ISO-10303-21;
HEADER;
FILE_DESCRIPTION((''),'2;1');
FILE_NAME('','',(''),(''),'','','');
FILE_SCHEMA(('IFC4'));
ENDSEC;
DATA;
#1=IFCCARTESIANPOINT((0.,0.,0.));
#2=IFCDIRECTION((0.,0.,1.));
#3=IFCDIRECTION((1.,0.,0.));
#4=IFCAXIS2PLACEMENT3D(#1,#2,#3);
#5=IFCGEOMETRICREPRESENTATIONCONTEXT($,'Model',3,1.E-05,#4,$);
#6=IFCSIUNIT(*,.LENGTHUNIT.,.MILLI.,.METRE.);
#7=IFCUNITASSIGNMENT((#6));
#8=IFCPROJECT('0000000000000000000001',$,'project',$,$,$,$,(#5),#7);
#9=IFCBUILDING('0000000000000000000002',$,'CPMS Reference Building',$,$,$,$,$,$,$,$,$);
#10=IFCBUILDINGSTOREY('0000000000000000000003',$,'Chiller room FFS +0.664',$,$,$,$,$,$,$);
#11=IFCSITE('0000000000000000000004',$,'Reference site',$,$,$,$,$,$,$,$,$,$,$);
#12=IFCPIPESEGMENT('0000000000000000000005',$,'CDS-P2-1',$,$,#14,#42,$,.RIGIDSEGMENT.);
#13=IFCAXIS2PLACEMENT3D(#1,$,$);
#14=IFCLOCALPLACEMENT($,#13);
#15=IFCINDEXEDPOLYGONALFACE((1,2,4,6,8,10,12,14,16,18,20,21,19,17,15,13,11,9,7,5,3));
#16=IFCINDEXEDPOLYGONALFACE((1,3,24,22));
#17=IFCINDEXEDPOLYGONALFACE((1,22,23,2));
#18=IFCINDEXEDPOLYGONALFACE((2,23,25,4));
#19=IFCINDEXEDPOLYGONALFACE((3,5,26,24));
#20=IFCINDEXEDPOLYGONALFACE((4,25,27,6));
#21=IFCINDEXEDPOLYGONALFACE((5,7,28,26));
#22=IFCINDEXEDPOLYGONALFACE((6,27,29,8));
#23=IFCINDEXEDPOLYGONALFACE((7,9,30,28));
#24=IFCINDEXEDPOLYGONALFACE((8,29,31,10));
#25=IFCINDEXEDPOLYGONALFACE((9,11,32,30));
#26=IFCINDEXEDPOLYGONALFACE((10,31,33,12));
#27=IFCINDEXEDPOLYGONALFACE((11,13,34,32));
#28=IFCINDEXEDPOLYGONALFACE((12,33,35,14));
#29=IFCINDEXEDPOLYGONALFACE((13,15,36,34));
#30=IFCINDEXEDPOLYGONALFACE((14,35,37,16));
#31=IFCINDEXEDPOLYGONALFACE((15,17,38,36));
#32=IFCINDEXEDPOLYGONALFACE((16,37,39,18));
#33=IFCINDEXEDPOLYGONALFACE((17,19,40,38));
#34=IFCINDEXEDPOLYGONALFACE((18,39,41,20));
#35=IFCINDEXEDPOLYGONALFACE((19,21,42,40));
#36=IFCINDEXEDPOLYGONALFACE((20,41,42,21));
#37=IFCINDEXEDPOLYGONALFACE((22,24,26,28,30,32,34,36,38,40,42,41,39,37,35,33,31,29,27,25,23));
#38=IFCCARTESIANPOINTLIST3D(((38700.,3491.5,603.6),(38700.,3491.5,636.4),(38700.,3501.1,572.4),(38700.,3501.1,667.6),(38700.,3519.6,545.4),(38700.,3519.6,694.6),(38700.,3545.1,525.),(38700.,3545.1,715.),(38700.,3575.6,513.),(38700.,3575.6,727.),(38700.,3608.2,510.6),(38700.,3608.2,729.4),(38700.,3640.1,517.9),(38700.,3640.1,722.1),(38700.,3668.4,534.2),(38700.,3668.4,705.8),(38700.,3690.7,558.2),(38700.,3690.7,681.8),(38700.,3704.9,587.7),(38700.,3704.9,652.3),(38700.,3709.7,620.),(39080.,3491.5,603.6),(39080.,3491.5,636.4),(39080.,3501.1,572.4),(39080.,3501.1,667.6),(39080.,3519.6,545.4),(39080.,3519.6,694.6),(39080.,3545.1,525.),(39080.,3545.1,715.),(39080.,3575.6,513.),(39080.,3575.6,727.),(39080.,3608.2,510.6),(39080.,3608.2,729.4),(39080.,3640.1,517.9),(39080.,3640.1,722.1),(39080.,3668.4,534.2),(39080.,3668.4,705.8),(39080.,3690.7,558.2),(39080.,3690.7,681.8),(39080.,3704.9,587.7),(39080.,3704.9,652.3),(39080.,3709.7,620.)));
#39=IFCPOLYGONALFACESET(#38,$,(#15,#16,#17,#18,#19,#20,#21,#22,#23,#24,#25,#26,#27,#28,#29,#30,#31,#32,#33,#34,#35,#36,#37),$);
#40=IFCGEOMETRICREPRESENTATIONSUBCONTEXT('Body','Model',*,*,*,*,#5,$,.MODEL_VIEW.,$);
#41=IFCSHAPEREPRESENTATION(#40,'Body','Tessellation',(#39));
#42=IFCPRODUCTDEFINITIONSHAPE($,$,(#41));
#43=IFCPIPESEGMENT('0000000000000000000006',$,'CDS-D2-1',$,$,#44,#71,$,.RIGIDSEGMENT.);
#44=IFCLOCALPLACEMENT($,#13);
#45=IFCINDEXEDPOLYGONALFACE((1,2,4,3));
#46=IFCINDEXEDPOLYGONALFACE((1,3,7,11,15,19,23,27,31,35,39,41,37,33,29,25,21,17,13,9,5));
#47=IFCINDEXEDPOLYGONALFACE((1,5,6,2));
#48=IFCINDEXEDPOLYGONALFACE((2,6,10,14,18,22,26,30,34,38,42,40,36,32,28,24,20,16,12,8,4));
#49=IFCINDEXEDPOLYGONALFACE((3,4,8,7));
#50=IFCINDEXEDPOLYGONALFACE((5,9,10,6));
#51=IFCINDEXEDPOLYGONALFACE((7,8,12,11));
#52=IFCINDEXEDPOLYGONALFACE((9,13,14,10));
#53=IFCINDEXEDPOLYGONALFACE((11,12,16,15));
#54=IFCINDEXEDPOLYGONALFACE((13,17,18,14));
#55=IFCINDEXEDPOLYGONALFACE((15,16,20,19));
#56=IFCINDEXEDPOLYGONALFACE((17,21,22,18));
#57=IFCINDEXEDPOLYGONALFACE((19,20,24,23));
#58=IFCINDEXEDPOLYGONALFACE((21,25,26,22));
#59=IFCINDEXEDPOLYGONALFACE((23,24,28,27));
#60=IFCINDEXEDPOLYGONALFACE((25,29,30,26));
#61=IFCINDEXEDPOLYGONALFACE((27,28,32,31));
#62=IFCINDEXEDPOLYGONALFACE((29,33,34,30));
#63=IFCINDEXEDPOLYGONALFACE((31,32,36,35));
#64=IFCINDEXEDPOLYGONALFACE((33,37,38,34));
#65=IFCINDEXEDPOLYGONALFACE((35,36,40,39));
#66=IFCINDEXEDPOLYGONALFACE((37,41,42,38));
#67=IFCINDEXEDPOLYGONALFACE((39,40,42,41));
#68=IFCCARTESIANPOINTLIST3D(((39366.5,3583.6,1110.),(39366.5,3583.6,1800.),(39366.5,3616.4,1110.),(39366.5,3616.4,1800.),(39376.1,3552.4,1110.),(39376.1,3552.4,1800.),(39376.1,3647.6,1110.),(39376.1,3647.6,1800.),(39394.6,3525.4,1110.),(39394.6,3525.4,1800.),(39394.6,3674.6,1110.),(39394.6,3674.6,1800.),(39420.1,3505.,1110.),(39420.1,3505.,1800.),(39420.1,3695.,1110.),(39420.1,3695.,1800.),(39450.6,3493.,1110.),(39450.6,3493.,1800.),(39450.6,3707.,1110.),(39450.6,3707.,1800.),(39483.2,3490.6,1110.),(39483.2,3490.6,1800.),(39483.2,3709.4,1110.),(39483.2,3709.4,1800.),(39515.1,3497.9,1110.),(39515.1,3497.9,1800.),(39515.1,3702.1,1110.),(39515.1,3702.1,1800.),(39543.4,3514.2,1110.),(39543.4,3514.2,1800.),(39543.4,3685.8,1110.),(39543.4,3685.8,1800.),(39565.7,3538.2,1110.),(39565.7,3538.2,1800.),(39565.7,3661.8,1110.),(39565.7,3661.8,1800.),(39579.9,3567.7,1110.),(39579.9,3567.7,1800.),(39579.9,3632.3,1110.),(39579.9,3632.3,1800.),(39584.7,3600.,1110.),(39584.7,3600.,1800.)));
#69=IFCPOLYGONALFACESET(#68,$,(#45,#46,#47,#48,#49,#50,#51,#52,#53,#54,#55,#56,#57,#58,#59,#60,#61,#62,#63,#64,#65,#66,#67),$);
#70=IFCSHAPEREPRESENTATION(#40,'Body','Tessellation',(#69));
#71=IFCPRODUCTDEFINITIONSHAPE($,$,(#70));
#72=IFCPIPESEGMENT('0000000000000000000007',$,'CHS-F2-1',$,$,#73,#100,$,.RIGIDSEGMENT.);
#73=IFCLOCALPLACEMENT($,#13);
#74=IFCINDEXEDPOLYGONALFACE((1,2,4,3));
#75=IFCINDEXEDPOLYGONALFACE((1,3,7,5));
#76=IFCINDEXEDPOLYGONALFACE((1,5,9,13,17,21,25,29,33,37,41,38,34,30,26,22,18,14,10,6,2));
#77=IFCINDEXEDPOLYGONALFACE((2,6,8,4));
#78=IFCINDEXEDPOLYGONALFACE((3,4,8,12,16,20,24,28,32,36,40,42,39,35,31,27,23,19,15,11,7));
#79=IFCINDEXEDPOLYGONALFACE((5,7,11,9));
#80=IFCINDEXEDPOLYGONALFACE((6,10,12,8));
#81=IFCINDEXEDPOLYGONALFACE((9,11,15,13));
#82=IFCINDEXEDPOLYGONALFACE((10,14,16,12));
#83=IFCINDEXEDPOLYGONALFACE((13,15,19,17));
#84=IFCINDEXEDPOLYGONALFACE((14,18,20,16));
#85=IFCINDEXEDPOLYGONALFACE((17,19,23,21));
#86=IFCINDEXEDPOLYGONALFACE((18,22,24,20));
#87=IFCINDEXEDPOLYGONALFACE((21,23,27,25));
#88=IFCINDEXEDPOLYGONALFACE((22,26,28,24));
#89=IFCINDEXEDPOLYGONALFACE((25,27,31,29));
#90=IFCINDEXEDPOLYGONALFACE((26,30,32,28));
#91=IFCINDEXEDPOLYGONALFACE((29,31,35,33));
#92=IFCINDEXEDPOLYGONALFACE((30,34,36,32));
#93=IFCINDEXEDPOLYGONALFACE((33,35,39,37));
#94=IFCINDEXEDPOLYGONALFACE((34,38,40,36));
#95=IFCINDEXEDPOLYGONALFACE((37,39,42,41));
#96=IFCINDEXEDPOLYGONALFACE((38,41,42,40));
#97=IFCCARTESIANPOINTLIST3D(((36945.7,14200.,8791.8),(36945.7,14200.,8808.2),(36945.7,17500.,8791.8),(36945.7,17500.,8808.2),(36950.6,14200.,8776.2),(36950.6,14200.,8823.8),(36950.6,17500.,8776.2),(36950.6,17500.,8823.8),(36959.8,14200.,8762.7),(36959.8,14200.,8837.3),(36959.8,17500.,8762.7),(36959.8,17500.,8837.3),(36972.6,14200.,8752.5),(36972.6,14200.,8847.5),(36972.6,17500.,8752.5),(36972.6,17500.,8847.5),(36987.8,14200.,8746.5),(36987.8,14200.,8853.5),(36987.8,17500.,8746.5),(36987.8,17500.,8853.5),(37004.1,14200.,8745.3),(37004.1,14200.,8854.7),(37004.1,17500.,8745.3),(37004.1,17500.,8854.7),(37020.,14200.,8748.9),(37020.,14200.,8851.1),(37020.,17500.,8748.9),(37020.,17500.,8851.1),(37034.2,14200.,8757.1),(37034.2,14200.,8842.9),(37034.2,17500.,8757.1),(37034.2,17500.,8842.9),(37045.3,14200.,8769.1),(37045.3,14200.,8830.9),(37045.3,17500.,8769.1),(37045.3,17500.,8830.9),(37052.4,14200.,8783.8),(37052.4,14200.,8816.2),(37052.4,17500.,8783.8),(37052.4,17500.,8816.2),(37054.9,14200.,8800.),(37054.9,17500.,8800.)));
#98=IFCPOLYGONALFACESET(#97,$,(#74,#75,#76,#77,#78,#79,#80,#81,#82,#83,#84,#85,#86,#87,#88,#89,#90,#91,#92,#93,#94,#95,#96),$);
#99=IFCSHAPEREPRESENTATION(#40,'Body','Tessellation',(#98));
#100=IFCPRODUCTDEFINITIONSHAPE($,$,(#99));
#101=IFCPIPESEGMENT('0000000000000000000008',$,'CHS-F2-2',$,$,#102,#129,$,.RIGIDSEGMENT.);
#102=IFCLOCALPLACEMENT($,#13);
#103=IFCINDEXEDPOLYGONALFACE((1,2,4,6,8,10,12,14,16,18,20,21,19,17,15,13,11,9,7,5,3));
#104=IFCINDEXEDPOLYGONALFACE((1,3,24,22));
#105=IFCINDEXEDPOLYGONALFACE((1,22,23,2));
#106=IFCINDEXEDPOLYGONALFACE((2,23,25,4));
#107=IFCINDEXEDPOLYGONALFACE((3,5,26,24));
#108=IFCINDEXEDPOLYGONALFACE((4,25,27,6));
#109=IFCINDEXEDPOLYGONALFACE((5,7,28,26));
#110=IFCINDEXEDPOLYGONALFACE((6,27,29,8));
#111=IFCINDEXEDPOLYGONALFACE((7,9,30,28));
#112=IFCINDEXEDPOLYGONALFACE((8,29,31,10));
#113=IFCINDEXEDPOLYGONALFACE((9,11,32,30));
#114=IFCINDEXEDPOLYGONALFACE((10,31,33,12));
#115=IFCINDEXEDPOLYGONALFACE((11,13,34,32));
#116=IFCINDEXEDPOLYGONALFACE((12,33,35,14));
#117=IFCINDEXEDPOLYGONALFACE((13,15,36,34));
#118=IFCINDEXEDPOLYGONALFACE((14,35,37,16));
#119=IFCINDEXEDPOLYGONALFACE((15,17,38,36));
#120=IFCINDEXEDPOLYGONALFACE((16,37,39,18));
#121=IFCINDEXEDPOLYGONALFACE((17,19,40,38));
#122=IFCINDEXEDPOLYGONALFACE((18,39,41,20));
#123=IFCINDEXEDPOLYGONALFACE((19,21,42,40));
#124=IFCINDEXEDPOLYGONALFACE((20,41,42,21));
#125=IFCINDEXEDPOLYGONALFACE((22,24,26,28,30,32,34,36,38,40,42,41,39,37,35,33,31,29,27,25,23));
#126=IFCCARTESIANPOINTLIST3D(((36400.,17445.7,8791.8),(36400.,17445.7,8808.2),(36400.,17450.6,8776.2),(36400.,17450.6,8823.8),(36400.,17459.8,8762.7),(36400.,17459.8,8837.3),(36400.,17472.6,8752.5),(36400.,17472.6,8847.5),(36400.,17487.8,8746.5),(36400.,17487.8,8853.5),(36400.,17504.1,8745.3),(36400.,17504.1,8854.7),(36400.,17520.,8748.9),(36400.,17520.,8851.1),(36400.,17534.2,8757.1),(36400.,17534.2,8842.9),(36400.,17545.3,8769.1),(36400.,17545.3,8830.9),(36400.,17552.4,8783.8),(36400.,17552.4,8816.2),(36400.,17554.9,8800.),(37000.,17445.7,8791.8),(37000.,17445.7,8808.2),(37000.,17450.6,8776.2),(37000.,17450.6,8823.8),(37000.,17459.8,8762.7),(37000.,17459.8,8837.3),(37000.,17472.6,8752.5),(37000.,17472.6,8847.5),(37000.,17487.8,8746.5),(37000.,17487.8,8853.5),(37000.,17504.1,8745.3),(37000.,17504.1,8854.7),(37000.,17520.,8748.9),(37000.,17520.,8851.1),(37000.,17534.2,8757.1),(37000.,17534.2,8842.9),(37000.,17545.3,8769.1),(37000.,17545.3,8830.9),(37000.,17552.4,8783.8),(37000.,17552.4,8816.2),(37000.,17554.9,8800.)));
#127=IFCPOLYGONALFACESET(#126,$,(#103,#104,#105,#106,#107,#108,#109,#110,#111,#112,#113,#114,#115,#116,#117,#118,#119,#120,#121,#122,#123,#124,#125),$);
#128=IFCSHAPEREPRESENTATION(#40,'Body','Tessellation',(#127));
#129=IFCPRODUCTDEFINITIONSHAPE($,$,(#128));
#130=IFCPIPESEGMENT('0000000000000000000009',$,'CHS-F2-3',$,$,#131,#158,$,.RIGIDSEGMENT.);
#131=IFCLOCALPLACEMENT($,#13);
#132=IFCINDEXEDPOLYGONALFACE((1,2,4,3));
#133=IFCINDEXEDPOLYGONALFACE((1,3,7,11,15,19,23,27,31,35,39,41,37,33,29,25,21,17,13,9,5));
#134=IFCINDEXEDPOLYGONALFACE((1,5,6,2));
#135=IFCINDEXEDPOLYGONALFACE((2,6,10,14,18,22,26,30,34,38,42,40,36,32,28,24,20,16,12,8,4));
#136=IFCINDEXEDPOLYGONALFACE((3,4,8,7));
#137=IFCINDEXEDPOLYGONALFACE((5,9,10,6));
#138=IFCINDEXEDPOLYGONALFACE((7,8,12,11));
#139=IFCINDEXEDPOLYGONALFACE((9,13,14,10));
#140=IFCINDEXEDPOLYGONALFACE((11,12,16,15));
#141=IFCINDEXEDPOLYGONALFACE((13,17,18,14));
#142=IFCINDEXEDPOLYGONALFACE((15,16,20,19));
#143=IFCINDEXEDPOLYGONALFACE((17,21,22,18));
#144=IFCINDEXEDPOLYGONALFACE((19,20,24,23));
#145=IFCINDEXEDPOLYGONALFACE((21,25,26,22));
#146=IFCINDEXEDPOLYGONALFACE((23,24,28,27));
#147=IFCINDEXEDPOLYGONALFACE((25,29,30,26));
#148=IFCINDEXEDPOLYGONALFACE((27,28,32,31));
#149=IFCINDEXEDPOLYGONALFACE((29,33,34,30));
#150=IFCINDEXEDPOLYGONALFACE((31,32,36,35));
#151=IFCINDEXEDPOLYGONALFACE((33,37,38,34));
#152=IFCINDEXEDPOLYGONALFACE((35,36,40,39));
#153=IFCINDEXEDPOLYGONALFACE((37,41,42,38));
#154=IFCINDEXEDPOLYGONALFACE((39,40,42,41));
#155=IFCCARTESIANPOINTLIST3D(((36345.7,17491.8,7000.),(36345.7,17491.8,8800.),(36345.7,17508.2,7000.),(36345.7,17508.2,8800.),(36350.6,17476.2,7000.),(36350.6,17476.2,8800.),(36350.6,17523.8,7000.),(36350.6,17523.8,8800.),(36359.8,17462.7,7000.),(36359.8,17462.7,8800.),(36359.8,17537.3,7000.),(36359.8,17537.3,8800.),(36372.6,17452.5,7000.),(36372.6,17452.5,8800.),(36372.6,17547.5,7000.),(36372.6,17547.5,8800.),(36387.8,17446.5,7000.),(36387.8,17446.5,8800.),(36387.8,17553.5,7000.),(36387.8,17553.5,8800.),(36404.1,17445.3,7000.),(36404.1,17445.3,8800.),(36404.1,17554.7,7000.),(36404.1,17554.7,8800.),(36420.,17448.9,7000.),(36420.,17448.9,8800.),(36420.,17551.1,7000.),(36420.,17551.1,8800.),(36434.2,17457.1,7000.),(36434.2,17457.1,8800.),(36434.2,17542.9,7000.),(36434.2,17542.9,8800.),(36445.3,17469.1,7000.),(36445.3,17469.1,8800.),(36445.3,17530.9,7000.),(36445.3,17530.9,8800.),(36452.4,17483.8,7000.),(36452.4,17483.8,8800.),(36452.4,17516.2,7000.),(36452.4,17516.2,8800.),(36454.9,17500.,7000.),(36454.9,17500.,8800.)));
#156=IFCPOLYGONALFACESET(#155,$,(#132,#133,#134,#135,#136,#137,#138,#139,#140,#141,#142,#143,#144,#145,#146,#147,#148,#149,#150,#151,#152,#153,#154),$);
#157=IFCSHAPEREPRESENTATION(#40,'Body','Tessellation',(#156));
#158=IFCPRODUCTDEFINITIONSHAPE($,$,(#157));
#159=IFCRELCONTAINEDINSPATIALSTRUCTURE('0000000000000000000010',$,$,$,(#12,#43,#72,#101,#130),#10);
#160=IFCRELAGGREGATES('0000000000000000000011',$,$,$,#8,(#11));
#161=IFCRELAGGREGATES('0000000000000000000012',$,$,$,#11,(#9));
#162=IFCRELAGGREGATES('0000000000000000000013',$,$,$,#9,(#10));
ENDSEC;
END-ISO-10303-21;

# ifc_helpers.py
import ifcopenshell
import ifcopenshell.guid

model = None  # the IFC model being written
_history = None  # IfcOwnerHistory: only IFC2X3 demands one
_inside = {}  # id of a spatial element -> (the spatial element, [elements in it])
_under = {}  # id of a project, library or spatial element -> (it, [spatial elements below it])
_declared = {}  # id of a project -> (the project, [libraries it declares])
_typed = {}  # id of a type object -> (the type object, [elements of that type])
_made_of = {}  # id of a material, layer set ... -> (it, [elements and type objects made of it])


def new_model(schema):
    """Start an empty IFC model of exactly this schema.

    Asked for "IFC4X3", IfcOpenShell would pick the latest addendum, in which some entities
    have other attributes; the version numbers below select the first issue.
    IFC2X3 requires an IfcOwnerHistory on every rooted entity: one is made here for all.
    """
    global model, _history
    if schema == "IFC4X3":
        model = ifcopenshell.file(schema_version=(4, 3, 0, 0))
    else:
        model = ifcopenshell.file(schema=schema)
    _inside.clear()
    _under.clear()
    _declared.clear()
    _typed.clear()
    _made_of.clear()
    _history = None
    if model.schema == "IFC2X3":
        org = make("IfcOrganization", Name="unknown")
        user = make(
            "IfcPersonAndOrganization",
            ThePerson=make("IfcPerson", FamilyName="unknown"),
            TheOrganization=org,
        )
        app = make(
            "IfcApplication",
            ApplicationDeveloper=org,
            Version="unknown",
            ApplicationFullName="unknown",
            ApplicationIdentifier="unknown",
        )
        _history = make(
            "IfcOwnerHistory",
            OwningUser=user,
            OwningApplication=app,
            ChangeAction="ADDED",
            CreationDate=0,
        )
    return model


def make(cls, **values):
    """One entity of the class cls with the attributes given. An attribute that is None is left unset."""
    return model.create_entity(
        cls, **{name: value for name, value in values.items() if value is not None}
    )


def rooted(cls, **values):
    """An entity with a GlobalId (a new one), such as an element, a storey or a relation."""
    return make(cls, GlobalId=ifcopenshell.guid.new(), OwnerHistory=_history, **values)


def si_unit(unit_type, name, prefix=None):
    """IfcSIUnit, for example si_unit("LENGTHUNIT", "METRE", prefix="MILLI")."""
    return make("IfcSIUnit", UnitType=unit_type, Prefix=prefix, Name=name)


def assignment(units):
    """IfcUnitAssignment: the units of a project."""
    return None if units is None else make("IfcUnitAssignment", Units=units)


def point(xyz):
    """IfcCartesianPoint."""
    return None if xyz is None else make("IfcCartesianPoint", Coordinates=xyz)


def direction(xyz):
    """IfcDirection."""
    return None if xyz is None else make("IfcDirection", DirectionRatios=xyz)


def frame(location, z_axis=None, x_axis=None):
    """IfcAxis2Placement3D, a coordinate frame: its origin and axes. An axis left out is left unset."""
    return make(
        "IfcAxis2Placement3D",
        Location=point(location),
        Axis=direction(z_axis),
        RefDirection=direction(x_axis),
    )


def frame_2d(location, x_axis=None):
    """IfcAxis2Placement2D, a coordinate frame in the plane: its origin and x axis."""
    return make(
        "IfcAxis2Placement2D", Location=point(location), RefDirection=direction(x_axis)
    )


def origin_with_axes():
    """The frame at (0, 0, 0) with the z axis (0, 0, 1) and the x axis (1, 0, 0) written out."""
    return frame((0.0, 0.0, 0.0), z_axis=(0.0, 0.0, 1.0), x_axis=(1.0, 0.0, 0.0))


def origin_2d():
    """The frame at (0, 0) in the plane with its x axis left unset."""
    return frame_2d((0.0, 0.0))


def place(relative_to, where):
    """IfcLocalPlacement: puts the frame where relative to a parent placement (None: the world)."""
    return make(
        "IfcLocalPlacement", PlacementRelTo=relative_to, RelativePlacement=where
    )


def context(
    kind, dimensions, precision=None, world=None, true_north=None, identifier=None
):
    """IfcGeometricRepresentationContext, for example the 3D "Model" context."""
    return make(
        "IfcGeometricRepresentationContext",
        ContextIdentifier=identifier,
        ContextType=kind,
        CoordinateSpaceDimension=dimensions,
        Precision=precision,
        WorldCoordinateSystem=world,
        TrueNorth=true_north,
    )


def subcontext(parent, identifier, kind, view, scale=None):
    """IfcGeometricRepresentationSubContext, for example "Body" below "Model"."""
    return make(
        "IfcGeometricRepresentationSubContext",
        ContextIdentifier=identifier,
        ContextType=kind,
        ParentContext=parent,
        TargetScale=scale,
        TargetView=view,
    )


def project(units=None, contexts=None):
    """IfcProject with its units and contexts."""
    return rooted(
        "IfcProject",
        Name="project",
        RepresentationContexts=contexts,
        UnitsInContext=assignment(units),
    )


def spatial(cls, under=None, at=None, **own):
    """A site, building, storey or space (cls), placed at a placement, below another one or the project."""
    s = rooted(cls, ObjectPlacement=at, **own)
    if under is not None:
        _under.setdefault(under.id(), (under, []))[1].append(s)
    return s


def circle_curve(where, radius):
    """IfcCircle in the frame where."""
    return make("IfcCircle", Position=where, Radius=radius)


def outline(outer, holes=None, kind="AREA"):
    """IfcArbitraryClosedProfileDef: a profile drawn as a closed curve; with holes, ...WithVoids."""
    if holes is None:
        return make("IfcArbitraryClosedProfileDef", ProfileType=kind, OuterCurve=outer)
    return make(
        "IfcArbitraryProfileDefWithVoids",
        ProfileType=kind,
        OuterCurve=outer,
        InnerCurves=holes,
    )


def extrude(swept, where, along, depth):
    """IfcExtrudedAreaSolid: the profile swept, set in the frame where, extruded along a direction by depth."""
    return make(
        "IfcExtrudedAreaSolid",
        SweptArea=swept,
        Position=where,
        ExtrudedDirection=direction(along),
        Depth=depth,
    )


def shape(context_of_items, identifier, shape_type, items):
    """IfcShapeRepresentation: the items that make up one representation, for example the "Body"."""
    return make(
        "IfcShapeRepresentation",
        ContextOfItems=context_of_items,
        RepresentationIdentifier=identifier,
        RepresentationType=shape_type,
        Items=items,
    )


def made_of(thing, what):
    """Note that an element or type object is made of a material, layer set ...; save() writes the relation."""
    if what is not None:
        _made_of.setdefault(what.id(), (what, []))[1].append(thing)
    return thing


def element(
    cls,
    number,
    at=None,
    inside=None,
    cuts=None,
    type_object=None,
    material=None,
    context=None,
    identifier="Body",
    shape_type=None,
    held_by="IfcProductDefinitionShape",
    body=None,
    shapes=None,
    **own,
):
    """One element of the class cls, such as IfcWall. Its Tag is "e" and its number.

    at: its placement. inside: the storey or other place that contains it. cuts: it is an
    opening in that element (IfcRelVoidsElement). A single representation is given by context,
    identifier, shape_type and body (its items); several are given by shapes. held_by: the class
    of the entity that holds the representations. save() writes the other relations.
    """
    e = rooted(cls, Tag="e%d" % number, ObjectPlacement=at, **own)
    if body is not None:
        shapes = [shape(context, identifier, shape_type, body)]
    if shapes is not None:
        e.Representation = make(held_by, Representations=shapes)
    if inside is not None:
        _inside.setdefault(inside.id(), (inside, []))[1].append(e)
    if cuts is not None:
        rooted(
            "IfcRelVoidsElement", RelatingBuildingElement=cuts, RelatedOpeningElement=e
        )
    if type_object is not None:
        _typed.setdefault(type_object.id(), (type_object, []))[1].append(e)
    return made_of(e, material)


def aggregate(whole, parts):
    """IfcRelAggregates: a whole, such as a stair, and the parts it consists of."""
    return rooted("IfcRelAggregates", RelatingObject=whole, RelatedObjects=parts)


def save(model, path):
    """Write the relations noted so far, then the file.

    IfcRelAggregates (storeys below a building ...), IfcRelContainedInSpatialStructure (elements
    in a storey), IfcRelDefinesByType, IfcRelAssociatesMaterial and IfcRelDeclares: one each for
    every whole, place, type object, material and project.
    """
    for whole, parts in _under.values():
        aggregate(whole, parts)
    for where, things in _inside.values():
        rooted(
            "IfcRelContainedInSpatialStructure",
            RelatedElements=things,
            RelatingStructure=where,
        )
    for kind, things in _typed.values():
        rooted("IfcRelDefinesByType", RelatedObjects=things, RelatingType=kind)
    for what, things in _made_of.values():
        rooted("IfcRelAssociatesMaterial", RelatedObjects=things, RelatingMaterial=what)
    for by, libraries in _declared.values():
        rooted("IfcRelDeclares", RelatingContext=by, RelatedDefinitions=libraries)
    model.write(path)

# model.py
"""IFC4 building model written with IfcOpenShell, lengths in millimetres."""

from ifc_helpers import new_model, si_unit, frame, origin_with_axes, origin_2d, place, context, subcontext, project, spatial, circle_curve, outline, extrude, element, save


model = new_model("IFC4")

# Units and contexts
model_context = context("Model", 3, precision=1e-05, world=origin_with_axes())
body_context = subcontext(model_context, "Body", "Model", "MODEL_VIEW")
ifc_project = project(units=[si_unit("LENGTHUNIT", "METRE", prefix="MILLI")], contexts=[model_context])

# Site, building, storey
site = spatial("IfcSite", under=ifc_project, Name="Reference site")
building = spatial("IfcBuilding", under=site, Name="CPMS Reference Building")
storey = spatial("IfcBuildingStorey", under=building, Name="Chiller room FFS +0.664")

# Pipe segments
pipe_segment_1_placement = place(None, origin_with_axes())
element("IfcPipeSegment", 1, at=pipe_segment_1_placement, inside=storey, Name="CDS-P2-1", PredefinedType="RIGIDSEGMENT", context=body_context, shape_type="SweptSolid", body=[
    extrude(outline(circle_curve(origin_2d(), 109.7)), frame((38700.0, 3600.0, 620.0), z_axis=(1.0, 0.0, 0.0), x_axis=(0.0, 1.0, 0.0)), (0.0, 0.0, 1.0), 380.0),
])
pipe_segment_2_placement = place(None, origin_with_axes())
element("IfcPipeSegment", 2, at=pipe_segment_2_placement, inside=storey, Name="CDS-D2-1", PredefinedType="RIGIDSEGMENT", context=body_context, shape_type="SweptSolid", body=[
    extrude(outline(circle_curve(origin_2d(), 109.7)), frame((39475.0, 3600.0, 1110.0), z_axis=(0.0, 0.0, 1.0), x_axis=(1.0, 0.0, 0.0)), (0.0, 0.0, 1.0), 690.0),
])
pipe_segment_3_placement = place(None, origin_with_axes())
element("IfcPipeSegment", 3, at=pipe_segment_3_placement, inside=storey, Name="CHS-F2-1", PredefinedType="RIGIDSEGMENT", context=body_context, shape_type="SweptSolid", body=[
    extrude(outline(circle_curve(origin_2d(), 54.9)), frame((37000.0, 14200.0, 8800.0), z_axis=(0.0, 1.0, 0.0), x_axis=(1.0, 0.0, 0.0)), (0.0, 0.0, 1.0), 3300.0),
])
pipe_segment_4_placement = place(None, origin_with_axes())
element("IfcPipeSegment", 4, at=pipe_segment_4_placement, inside=storey, Name="CHS-F2-2", PredefinedType="RIGIDSEGMENT", context=body_context, shape_type="SweptSolid", body=[
    extrude(outline(circle_curve(origin_2d(), 54.9)), frame((37000.0, 17500.0, 8800.0), z_axis=(-1.0, 0.0, 0.0), x_axis=(0.0, 1.0, 0.0)), (0.0, 0.0, 1.0), 600.0),
])
pipe_segment_5_placement = place(None, origin_with_axes())
element("IfcPipeSegment", 5, at=pipe_segment_5_placement, inside=storey, Name="CHS-F2-3", PredefinedType="RIGIDSEGMENT", context=body_context, shape_type="SweptSolid", body=[
    extrude(outline(circle_curve(origin_2d(), 54.9)), frame((36400.0, 17500.0, 8800.0), z_axis=(0.0, 0.0, -1.0), x_axis=(1.0, 0.0, 0.0)), (0.0, 0.0, 1.0), 1800.0),
])

save(model, "model.ifc")
